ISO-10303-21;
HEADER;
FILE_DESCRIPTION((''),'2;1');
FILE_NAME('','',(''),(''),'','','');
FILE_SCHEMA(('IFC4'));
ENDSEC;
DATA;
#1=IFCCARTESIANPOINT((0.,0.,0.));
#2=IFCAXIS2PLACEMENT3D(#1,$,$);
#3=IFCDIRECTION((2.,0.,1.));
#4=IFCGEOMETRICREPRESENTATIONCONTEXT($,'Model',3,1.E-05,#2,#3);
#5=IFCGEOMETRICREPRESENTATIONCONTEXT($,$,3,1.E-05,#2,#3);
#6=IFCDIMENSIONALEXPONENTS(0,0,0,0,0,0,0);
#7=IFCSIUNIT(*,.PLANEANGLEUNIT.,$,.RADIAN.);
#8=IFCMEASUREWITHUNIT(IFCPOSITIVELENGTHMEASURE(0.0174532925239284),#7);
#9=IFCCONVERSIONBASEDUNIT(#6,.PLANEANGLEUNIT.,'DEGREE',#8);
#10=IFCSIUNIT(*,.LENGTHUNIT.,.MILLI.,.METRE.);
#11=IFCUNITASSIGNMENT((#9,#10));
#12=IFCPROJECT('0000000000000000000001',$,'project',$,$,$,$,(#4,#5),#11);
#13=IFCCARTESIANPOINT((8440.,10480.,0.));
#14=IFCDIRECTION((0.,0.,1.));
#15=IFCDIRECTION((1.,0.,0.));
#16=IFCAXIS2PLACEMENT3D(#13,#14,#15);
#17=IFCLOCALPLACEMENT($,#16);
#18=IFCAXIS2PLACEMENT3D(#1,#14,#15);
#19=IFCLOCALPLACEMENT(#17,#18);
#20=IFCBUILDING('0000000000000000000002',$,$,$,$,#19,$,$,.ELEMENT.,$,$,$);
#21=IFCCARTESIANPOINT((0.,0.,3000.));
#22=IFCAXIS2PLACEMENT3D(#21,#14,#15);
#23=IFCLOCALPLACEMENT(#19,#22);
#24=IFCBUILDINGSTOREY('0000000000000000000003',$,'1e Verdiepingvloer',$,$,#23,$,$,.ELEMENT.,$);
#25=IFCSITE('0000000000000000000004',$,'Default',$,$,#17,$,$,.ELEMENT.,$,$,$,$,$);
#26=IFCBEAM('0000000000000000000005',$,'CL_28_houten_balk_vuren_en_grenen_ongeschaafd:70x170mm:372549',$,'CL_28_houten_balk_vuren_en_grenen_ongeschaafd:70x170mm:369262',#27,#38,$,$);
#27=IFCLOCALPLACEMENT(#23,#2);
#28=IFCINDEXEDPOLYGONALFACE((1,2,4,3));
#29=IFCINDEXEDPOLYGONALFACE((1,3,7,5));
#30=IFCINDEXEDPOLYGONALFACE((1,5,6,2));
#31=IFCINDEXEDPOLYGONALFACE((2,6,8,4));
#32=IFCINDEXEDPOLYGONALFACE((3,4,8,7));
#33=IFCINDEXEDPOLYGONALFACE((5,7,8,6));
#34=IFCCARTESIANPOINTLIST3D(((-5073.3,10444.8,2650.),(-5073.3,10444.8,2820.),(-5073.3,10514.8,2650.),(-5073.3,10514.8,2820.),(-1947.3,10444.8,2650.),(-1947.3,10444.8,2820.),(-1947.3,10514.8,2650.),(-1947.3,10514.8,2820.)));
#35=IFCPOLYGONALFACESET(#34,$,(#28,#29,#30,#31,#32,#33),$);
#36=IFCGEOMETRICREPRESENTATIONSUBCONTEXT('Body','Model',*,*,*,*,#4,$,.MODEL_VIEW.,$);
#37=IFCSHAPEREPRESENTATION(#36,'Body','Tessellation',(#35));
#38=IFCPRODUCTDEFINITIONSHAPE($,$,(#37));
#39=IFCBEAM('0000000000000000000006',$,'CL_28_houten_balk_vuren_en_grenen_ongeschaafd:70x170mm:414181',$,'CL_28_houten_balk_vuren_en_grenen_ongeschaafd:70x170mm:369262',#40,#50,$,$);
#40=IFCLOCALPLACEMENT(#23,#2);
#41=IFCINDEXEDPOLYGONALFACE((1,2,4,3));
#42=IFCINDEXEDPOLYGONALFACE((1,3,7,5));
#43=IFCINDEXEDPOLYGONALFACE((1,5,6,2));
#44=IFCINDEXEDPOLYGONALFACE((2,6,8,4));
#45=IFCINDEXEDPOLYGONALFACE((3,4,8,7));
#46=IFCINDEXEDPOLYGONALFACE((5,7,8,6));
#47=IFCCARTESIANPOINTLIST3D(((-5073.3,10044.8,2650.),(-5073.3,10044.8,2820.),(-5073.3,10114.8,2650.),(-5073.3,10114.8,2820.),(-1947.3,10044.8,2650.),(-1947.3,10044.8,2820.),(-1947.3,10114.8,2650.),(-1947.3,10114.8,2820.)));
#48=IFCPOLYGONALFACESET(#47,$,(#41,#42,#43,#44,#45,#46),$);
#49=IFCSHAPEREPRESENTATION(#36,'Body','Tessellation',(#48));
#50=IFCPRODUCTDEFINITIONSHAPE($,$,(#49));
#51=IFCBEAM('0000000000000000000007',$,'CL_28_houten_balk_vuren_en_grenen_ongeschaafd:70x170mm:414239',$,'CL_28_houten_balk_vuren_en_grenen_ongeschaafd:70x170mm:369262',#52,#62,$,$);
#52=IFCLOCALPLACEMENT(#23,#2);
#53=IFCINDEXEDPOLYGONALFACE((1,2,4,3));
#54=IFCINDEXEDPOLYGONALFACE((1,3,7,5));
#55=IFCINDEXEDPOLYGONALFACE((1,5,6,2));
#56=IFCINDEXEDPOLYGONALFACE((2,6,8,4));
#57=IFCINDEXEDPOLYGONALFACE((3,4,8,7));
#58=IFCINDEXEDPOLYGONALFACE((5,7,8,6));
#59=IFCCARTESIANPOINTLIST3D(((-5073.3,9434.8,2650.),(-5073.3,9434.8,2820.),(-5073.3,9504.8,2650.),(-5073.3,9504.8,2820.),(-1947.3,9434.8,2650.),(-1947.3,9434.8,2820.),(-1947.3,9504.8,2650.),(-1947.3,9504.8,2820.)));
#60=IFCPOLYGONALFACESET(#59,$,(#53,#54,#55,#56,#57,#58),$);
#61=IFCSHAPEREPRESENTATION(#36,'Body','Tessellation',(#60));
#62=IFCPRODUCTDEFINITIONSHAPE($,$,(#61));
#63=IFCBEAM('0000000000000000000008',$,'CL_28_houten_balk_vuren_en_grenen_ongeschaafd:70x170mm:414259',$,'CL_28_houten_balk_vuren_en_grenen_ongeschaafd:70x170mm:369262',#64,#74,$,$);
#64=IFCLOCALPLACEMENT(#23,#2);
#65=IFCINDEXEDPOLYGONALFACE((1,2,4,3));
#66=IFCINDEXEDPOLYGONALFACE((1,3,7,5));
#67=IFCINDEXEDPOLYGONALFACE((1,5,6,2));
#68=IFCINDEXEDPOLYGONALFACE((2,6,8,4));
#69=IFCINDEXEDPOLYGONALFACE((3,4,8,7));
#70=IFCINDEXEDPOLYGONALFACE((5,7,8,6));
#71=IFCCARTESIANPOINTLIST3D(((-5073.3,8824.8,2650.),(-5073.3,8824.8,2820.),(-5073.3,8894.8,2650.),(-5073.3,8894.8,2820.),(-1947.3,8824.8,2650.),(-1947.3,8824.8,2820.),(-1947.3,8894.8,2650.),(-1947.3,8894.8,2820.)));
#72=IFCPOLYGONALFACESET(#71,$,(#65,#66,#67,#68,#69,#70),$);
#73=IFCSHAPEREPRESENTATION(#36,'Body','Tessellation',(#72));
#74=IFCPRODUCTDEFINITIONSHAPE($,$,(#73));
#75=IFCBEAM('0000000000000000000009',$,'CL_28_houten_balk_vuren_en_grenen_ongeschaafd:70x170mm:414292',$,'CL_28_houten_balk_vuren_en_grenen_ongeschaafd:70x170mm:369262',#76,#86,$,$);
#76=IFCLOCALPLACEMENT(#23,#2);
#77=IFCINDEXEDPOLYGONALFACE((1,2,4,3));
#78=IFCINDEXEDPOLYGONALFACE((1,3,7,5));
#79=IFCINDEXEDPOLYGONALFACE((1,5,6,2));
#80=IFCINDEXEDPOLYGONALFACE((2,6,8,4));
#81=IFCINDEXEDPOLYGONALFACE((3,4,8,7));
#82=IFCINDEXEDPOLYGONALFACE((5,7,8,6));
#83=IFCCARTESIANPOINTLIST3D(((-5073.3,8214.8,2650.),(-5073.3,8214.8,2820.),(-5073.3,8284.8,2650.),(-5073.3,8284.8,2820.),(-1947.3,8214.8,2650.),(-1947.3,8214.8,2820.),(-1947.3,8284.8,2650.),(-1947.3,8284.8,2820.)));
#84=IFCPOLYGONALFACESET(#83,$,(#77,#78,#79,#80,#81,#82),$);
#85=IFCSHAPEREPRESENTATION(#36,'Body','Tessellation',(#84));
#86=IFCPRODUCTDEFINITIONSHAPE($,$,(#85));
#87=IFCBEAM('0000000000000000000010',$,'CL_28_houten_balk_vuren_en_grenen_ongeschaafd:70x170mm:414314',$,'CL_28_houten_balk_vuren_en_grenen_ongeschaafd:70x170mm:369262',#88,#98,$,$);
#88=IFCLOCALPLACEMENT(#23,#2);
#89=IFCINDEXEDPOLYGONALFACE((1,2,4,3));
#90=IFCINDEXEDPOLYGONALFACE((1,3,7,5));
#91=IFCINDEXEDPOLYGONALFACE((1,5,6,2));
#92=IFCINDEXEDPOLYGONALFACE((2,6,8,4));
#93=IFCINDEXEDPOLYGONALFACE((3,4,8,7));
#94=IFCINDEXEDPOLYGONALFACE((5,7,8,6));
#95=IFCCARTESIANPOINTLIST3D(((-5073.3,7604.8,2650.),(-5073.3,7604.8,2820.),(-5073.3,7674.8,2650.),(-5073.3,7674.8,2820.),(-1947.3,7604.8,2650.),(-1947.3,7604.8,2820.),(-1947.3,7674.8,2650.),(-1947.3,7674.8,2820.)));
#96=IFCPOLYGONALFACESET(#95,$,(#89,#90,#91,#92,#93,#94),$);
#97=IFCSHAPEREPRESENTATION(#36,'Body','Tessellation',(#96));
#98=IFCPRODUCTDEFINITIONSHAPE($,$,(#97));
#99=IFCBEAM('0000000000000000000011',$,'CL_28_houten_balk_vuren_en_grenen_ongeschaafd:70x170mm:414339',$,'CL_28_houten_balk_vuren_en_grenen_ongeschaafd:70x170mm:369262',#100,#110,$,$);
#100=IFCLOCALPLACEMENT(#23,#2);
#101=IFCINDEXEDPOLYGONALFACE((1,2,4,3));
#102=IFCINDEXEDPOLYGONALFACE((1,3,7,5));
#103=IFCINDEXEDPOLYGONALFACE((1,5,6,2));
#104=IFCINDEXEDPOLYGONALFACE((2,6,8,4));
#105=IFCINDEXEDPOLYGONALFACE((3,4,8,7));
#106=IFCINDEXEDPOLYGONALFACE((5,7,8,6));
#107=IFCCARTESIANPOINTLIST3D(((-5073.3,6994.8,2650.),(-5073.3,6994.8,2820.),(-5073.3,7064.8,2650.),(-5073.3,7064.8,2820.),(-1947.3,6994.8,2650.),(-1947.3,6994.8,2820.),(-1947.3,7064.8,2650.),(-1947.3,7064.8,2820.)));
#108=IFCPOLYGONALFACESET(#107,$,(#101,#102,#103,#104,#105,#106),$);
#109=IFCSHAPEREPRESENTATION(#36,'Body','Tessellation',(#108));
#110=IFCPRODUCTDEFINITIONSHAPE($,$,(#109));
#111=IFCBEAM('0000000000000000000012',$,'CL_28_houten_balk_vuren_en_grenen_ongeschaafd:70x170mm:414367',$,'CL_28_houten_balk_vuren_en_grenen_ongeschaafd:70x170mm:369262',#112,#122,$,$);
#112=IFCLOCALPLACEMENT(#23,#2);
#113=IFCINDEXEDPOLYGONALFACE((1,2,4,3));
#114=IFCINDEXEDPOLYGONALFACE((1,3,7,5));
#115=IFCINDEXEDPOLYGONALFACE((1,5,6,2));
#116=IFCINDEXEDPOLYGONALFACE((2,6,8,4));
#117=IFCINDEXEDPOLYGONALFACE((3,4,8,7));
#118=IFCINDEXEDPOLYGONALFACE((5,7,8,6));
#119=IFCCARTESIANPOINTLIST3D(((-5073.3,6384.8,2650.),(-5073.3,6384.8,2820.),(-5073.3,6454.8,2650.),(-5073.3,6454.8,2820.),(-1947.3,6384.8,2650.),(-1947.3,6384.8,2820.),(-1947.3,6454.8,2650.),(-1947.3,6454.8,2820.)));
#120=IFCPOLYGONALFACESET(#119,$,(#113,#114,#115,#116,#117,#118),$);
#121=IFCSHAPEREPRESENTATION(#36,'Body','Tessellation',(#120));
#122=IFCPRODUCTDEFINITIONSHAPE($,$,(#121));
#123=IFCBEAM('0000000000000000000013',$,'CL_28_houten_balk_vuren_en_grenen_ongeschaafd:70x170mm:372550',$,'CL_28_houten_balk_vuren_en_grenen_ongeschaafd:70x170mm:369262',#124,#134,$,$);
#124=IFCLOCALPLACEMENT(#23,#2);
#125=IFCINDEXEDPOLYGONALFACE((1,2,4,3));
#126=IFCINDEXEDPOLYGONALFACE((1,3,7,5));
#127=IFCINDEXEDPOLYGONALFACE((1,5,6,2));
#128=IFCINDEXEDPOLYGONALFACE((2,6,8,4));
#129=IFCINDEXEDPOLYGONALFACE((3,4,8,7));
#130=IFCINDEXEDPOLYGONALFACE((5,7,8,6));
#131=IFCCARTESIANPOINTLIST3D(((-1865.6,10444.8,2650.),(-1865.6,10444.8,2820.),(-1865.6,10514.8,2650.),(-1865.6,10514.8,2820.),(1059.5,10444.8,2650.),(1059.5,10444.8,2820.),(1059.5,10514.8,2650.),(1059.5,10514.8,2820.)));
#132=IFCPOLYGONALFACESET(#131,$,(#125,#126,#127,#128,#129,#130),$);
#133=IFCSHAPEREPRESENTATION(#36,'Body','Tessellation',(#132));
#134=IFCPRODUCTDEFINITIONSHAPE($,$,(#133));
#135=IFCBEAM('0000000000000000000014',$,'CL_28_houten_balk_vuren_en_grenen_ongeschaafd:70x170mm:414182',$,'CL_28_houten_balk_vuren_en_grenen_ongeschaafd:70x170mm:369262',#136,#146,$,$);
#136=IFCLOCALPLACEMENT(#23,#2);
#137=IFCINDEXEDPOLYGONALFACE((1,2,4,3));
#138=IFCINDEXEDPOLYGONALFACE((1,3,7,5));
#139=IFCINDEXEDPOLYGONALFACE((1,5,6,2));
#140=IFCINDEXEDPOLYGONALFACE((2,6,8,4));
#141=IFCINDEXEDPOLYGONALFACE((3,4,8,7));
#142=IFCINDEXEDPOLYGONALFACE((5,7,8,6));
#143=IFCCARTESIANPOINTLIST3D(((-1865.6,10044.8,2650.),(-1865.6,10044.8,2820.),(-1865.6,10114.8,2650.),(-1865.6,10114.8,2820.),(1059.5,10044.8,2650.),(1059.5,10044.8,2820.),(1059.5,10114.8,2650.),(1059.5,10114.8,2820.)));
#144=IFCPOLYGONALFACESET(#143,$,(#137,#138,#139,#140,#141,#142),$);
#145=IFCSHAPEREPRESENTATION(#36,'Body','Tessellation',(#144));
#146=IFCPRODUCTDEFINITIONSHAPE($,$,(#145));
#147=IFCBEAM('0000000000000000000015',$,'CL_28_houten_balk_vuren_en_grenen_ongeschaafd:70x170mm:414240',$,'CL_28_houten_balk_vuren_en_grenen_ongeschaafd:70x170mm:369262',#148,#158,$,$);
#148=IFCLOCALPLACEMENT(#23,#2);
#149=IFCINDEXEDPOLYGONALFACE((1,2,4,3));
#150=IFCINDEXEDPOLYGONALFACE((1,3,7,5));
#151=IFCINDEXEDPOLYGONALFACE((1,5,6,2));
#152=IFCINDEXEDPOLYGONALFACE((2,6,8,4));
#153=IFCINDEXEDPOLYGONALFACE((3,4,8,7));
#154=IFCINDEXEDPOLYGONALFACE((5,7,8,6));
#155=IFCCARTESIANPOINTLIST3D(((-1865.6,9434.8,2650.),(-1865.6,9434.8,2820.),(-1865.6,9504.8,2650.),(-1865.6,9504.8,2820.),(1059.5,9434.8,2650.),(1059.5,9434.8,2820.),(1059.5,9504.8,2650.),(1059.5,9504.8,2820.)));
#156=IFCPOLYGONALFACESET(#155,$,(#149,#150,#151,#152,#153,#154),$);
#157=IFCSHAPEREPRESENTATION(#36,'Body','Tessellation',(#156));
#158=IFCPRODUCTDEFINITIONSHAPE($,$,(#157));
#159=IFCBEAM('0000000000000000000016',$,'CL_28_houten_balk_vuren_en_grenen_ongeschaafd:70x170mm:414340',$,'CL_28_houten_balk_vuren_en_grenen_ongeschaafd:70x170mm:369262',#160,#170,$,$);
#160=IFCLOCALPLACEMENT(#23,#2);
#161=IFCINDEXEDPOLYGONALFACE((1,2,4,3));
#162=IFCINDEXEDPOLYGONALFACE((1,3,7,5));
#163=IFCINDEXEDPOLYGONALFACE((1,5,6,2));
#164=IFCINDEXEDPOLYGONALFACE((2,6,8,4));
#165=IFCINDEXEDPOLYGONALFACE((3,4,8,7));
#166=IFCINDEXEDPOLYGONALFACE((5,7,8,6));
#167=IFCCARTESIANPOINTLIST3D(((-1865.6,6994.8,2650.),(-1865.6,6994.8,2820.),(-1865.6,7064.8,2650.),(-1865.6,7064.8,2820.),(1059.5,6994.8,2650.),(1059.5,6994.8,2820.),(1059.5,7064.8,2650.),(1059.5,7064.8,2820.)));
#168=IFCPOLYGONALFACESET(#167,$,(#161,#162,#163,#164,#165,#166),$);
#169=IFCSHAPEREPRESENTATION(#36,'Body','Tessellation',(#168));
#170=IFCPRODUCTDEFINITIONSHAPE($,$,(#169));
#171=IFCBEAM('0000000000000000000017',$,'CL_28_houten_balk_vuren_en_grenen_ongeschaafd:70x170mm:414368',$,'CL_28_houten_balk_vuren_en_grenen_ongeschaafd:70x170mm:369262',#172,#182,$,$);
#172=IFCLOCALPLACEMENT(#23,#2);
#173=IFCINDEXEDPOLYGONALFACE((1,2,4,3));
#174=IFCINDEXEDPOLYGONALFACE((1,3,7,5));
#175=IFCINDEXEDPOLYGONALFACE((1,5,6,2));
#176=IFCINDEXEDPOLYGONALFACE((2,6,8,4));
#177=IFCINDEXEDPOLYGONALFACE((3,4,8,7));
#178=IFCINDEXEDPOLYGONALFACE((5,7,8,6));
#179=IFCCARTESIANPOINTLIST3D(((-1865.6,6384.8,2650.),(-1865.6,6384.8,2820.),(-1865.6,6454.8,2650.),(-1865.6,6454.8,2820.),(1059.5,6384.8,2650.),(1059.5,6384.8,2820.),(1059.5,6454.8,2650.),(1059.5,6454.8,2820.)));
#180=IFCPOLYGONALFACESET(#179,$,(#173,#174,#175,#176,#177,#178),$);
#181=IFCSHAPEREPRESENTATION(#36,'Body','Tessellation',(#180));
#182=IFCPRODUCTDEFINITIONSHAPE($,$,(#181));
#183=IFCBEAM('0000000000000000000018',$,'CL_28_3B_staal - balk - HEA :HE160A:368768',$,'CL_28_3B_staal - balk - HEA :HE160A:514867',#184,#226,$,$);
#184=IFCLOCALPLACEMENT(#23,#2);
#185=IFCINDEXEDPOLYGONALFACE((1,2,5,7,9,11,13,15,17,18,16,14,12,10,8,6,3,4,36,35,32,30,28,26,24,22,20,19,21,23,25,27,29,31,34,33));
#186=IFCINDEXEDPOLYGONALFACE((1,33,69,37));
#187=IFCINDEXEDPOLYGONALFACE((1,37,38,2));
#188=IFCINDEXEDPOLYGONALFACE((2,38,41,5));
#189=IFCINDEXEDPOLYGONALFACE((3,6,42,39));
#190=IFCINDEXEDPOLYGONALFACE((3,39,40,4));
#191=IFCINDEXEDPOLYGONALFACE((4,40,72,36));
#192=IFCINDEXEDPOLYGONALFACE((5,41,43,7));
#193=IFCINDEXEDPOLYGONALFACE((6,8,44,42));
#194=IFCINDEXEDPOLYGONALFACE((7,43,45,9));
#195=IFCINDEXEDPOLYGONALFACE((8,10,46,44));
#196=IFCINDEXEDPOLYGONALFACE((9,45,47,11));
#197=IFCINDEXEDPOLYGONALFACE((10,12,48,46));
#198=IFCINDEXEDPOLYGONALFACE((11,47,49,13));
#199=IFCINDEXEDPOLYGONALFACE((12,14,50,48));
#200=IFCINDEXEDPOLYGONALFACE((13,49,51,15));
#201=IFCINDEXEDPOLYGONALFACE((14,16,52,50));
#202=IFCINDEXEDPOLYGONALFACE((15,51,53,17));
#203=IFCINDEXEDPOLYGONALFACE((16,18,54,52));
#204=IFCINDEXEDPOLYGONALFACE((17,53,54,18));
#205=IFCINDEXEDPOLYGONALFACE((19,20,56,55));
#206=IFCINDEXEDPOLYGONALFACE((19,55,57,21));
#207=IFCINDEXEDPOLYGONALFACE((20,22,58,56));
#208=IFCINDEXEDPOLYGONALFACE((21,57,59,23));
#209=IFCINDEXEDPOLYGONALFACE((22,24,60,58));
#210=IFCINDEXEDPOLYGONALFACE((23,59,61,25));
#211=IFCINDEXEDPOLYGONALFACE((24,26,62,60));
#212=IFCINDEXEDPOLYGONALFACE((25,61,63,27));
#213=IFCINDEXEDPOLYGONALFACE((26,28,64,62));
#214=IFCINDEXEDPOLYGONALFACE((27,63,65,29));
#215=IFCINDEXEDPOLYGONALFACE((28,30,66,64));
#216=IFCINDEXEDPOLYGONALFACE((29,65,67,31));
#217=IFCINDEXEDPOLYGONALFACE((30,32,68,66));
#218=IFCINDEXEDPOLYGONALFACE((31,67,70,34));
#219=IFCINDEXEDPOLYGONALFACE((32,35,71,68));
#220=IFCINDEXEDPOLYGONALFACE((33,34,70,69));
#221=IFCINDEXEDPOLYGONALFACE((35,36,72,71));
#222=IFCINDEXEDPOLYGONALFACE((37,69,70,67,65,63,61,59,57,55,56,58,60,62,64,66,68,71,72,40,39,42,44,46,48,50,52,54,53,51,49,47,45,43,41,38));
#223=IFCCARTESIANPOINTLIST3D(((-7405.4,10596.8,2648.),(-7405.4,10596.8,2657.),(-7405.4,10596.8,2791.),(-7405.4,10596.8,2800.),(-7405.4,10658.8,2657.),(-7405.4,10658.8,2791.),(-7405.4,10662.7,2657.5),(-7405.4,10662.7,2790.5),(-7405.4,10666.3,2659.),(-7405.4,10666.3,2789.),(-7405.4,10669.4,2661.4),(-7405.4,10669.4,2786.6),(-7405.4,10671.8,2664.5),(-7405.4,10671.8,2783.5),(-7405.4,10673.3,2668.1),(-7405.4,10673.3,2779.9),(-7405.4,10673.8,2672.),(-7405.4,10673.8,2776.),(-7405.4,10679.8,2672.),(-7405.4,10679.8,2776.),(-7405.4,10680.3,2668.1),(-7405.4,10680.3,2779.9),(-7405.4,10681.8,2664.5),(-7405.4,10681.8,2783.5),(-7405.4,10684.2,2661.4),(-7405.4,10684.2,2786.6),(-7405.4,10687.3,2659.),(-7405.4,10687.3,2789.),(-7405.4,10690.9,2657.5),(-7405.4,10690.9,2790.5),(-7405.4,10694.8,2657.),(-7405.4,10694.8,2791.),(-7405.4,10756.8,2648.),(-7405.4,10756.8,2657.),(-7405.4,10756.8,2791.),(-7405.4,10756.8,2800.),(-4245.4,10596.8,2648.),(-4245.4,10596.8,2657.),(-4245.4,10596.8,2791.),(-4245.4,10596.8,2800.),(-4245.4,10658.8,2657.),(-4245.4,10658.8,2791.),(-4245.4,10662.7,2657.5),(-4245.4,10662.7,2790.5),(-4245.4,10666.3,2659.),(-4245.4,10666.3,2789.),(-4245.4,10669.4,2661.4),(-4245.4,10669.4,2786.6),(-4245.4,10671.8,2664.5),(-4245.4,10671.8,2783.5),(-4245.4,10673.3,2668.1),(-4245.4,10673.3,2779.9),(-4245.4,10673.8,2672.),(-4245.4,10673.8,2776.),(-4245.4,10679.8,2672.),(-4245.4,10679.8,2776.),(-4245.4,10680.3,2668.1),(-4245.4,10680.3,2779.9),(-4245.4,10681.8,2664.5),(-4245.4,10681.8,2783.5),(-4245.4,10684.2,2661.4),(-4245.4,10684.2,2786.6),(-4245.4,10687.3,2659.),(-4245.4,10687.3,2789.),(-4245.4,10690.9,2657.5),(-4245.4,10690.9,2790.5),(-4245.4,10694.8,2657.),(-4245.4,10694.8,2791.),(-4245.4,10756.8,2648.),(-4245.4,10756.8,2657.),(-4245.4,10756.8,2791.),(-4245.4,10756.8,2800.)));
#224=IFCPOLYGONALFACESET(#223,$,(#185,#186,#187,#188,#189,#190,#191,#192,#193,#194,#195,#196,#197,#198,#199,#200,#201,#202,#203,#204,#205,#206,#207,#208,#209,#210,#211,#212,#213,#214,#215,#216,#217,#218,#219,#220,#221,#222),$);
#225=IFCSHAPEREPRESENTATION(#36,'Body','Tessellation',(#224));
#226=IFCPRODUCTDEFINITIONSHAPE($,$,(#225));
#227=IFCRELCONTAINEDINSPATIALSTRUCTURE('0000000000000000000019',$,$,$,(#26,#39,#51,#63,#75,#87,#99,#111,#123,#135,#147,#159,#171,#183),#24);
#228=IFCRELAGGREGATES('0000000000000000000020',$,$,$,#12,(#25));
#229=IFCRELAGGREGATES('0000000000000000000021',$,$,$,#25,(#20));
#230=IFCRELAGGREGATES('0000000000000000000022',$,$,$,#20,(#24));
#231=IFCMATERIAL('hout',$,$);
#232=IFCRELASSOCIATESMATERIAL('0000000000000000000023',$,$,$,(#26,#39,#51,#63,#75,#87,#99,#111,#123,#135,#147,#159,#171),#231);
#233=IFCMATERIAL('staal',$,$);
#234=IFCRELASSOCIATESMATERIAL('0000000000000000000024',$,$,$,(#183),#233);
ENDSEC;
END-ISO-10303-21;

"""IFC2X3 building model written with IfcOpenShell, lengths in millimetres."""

from ifc_helpers import new_model, entity, si_unit, converted_unit, direction, frame, frame_2d, origin, origin_with_axes, place, context, subcontext, project, spatial, rectangle, i_section, extrude, source, transform, mapped, material, element, save


model = new_model("IFC2X3")

# Units and contexts
model_context = context("Model", 3, precision=1e-05, world=origin(), true_north=direction((2.0, 0.0, 1.0)))
context_of_model = context(None, 3, precision=1e-05, world=origin(), true_north=direction((2.0, 0.0, 1.0)))
body_context = subcontext(model_context, "Body", "Model", "MODEL_VIEW")
ifc_project = project(units=[converted_unit("PLANEANGLEUNIT", "DEGREE", entity("IfcPositiveLengthMeasure", 0.0174532925239284), si_unit("PLANEANGLEUNIT", "RADIAN"), dimensions=[0, 0, 0, 0, 0, 0, 0]), si_unit("LENGTHUNIT", "METRE", prefix="MILLI")], contexts=[model_context, context_of_model])

# Site, building, storey
site_placement = place(None, frame((8440.0, 10480.0, 0.0), z_axis=(0.0, 0.0, 1.0), x_axis=(1.0, 0.0, 0.0)))
site = spatial("IfcSite", under=ifc_project, at=site_placement, Name="Default", CompositionType="ELEMENT")
building_placement = place(site_placement, origin_with_axes())
building = spatial("IfcBuilding", under=site, at=building_placement, CompositionType="ELEMENT")
storey_placement = place(building_placement, frame((0.0, 0.0, 3000.0), z_axis=(0.0, 0.0, 1.0), x_axis=(1.0, 0.0, 0.0)))
storey = spatial("IfcBuildingStorey", under=building, at=storey_placement, Name="1e Verdiepingvloer", CompositionType="ELEMENT")

# Beams
ifc_material_1 = material(Name="hout")
shared_shape_1 = source(origin(), body_context, "Body", "SweptSolid", [
    extrude(rectangle(XDim=170.0, YDim=70.0, at=frame_2d((0.0, 0.0), x_axis=(1.0, 0.0))), frame((155.6, 0.0, -85.0), z_axis=(1.0, 0.0, 0.0), x_axis=(0.0, 0.0, -1.0)), (0.0, 0.0, 1.0), 3126.0),
])
for number, where, z_axis, x_axis, name in (
    (1, (-5228.9, 10479.8, 2820.0), (0.0, 0.0, 1.0), (1.0, 0.0, 0.0), "CL_28_houten_balk_vuren_en_grenen_ongeschaafd:70x170mm:372549"),
    (2, (-5228.9, 10079.8, 2820.0), (0.0, 0.0, 1.0), (1.0, 0.0, 0.0), "CL_28_houten_balk_vuren_en_grenen_ongeschaafd:70x170mm:414181"),
    (3, (-5228.9, 9469.8, 2820.0), (0.0, 0.0, 1.0), (1.0, 0.0, 0.0), "CL_28_houten_balk_vuren_en_grenen_ongeschaafd:70x170mm:414239"),
    (4, (-5228.9, 8859.8, 2820.0), (0.0, 0.0, 1.0), (1.0, 0.0, 0.0), "CL_28_houten_balk_vuren_en_grenen_ongeschaafd:70x170mm:414259"),
    (5, (-5228.9, 8249.8, 2820.0), (0.0, 0.0, 1.0), (1.0, 0.0, 0.0), "CL_28_houten_balk_vuren_en_grenen_ongeschaafd:70x170mm:414292"),
    (6, (-5228.9, 7639.8, 2820.0), (0.0, 0.0, 1.0), (1.0, 0.0, 0.0), "CL_28_houten_balk_vuren_en_grenen_ongeschaafd:70x170mm:414314"),
    (7, (-5228.9, 7029.8, 2820.0), (0.0, 0.0, 1.0), (1.0, 0.0, 0.0), "CL_28_houten_balk_vuren_en_grenen_ongeschaafd:70x170mm:414339"),
    (8, (-5228.9, 6419.8, 2820.0), (0.0, 0.0, 1.0), (1.0, 0.0, 0.0), "CL_28_houten_balk_vuren_en_grenen_ongeschaafd:70x170mm:414367"),
):
    element("IfcBeam", number, at=place(storey_placement, frame(where, z_axis=z_axis, x_axis=x_axis)), inside=storey, material=ifc_material_1, Name=name, ObjectType="CL_28_houten_balk_vuren_en_grenen_ongeschaafd:70x170mm:369262", context=body_context, shape_type="MappedRepresentation", body=[
        mapped(shared_shape_1, transform((0.0, 0.0, 0.0))),
    ])
shared_shape_2 = source(origin(), body_context, "Body", "SweptSolid", [
    extrude(rectangle(XDim=170.0, YDim=70.0, at=frame_2d((0.0, 0.0), x_axis=(1.0, 0.0))), frame((263.4, 0.0, -85.0), z_axis=(1.0, 0.0, 0.0), x_axis=(0.0, 0.0, -1.0)), (0.0, 0.0, 1.0), 2925.0),
])
for number, where, z_axis, x_axis, name in (
    (9, (-2128.9, 10479.8, 2820.0), (0.0, 0.0, 1.0), (1.0, 0.0, 0.0), "CL_28_houten_balk_vuren_en_grenen_ongeschaafd:70x170mm:372550"),
    (10, (-2128.9, 10079.8, 2820.0), (0.0, 0.0, 1.0), (1.0, 0.0, 0.0), "CL_28_houten_balk_vuren_en_grenen_ongeschaafd:70x170mm:414182"),
    (11, (-2128.9, 9469.8, 2820.0), (0.0, 0.0, 1.0), (1.0, 0.0, 0.0), "CL_28_houten_balk_vuren_en_grenen_ongeschaafd:70x170mm:414240"),
    (12, (-2128.9, 7029.8, 2820.0), (0.0, 0.0, 1.0), (1.0, 0.0, 0.0), "CL_28_houten_balk_vuren_en_grenen_ongeschaafd:70x170mm:414340"),
    (13, (-2128.9, 6419.8, 2820.0), (0.0, 0.0, 1.0), (1.0, 0.0, 0.0), "CL_28_houten_balk_vuren_en_grenen_ongeschaafd:70x170mm:414368"),
):
    element("IfcBeam", number, at=place(storey_placement, frame(where, z_axis=z_axis, x_axis=x_axis)), inside=storey, material=ifc_material_1, Name=name, ObjectType="CL_28_houten_balk_vuren_en_grenen_ongeschaafd:70x170mm:369262", context=body_context, shape_type="MappedRepresentation", body=[
        mapped(shared_shape_2, transform((0.0, 0.0, 0.0))),
    ])
ifc_material_2 = material(Name="staal")
beam_1_placement = place(storey_placement, frame((-7252.9, 10676.8, 2800.0), z_axis=(0.0, 0.0, 1.0), x_axis=(1.0, 0.0, 0.0)))
element("IfcBeam", 14, at=beam_1_placement, inside=storey, material=ifc_material_2, Name="CL_28_3B_staal - balk - HEA :HE160A:368768", ObjectType="CL_28_3B_staal - balk - HEA :HE160A:514867", context=body_context, shape_type="SweptSolid", body=[
    extrude(i_section(OverallWidth=160.0, OverallDepth=152.0, WebThickness=6.0, FlangeThickness=9.0, FilletRadius=15.0, at=frame_2d((0.0, 0.0), x_axis=(0.0, 1.0))), frame((-152.5, 0.0, -76.0), z_axis=(1.0, 0.0, 0.0), x_axis=(0.0, 0.0, -1.0)), (0.0, 0.0, 1.0), 3160.0),
])

save(model, "model.ifc")
